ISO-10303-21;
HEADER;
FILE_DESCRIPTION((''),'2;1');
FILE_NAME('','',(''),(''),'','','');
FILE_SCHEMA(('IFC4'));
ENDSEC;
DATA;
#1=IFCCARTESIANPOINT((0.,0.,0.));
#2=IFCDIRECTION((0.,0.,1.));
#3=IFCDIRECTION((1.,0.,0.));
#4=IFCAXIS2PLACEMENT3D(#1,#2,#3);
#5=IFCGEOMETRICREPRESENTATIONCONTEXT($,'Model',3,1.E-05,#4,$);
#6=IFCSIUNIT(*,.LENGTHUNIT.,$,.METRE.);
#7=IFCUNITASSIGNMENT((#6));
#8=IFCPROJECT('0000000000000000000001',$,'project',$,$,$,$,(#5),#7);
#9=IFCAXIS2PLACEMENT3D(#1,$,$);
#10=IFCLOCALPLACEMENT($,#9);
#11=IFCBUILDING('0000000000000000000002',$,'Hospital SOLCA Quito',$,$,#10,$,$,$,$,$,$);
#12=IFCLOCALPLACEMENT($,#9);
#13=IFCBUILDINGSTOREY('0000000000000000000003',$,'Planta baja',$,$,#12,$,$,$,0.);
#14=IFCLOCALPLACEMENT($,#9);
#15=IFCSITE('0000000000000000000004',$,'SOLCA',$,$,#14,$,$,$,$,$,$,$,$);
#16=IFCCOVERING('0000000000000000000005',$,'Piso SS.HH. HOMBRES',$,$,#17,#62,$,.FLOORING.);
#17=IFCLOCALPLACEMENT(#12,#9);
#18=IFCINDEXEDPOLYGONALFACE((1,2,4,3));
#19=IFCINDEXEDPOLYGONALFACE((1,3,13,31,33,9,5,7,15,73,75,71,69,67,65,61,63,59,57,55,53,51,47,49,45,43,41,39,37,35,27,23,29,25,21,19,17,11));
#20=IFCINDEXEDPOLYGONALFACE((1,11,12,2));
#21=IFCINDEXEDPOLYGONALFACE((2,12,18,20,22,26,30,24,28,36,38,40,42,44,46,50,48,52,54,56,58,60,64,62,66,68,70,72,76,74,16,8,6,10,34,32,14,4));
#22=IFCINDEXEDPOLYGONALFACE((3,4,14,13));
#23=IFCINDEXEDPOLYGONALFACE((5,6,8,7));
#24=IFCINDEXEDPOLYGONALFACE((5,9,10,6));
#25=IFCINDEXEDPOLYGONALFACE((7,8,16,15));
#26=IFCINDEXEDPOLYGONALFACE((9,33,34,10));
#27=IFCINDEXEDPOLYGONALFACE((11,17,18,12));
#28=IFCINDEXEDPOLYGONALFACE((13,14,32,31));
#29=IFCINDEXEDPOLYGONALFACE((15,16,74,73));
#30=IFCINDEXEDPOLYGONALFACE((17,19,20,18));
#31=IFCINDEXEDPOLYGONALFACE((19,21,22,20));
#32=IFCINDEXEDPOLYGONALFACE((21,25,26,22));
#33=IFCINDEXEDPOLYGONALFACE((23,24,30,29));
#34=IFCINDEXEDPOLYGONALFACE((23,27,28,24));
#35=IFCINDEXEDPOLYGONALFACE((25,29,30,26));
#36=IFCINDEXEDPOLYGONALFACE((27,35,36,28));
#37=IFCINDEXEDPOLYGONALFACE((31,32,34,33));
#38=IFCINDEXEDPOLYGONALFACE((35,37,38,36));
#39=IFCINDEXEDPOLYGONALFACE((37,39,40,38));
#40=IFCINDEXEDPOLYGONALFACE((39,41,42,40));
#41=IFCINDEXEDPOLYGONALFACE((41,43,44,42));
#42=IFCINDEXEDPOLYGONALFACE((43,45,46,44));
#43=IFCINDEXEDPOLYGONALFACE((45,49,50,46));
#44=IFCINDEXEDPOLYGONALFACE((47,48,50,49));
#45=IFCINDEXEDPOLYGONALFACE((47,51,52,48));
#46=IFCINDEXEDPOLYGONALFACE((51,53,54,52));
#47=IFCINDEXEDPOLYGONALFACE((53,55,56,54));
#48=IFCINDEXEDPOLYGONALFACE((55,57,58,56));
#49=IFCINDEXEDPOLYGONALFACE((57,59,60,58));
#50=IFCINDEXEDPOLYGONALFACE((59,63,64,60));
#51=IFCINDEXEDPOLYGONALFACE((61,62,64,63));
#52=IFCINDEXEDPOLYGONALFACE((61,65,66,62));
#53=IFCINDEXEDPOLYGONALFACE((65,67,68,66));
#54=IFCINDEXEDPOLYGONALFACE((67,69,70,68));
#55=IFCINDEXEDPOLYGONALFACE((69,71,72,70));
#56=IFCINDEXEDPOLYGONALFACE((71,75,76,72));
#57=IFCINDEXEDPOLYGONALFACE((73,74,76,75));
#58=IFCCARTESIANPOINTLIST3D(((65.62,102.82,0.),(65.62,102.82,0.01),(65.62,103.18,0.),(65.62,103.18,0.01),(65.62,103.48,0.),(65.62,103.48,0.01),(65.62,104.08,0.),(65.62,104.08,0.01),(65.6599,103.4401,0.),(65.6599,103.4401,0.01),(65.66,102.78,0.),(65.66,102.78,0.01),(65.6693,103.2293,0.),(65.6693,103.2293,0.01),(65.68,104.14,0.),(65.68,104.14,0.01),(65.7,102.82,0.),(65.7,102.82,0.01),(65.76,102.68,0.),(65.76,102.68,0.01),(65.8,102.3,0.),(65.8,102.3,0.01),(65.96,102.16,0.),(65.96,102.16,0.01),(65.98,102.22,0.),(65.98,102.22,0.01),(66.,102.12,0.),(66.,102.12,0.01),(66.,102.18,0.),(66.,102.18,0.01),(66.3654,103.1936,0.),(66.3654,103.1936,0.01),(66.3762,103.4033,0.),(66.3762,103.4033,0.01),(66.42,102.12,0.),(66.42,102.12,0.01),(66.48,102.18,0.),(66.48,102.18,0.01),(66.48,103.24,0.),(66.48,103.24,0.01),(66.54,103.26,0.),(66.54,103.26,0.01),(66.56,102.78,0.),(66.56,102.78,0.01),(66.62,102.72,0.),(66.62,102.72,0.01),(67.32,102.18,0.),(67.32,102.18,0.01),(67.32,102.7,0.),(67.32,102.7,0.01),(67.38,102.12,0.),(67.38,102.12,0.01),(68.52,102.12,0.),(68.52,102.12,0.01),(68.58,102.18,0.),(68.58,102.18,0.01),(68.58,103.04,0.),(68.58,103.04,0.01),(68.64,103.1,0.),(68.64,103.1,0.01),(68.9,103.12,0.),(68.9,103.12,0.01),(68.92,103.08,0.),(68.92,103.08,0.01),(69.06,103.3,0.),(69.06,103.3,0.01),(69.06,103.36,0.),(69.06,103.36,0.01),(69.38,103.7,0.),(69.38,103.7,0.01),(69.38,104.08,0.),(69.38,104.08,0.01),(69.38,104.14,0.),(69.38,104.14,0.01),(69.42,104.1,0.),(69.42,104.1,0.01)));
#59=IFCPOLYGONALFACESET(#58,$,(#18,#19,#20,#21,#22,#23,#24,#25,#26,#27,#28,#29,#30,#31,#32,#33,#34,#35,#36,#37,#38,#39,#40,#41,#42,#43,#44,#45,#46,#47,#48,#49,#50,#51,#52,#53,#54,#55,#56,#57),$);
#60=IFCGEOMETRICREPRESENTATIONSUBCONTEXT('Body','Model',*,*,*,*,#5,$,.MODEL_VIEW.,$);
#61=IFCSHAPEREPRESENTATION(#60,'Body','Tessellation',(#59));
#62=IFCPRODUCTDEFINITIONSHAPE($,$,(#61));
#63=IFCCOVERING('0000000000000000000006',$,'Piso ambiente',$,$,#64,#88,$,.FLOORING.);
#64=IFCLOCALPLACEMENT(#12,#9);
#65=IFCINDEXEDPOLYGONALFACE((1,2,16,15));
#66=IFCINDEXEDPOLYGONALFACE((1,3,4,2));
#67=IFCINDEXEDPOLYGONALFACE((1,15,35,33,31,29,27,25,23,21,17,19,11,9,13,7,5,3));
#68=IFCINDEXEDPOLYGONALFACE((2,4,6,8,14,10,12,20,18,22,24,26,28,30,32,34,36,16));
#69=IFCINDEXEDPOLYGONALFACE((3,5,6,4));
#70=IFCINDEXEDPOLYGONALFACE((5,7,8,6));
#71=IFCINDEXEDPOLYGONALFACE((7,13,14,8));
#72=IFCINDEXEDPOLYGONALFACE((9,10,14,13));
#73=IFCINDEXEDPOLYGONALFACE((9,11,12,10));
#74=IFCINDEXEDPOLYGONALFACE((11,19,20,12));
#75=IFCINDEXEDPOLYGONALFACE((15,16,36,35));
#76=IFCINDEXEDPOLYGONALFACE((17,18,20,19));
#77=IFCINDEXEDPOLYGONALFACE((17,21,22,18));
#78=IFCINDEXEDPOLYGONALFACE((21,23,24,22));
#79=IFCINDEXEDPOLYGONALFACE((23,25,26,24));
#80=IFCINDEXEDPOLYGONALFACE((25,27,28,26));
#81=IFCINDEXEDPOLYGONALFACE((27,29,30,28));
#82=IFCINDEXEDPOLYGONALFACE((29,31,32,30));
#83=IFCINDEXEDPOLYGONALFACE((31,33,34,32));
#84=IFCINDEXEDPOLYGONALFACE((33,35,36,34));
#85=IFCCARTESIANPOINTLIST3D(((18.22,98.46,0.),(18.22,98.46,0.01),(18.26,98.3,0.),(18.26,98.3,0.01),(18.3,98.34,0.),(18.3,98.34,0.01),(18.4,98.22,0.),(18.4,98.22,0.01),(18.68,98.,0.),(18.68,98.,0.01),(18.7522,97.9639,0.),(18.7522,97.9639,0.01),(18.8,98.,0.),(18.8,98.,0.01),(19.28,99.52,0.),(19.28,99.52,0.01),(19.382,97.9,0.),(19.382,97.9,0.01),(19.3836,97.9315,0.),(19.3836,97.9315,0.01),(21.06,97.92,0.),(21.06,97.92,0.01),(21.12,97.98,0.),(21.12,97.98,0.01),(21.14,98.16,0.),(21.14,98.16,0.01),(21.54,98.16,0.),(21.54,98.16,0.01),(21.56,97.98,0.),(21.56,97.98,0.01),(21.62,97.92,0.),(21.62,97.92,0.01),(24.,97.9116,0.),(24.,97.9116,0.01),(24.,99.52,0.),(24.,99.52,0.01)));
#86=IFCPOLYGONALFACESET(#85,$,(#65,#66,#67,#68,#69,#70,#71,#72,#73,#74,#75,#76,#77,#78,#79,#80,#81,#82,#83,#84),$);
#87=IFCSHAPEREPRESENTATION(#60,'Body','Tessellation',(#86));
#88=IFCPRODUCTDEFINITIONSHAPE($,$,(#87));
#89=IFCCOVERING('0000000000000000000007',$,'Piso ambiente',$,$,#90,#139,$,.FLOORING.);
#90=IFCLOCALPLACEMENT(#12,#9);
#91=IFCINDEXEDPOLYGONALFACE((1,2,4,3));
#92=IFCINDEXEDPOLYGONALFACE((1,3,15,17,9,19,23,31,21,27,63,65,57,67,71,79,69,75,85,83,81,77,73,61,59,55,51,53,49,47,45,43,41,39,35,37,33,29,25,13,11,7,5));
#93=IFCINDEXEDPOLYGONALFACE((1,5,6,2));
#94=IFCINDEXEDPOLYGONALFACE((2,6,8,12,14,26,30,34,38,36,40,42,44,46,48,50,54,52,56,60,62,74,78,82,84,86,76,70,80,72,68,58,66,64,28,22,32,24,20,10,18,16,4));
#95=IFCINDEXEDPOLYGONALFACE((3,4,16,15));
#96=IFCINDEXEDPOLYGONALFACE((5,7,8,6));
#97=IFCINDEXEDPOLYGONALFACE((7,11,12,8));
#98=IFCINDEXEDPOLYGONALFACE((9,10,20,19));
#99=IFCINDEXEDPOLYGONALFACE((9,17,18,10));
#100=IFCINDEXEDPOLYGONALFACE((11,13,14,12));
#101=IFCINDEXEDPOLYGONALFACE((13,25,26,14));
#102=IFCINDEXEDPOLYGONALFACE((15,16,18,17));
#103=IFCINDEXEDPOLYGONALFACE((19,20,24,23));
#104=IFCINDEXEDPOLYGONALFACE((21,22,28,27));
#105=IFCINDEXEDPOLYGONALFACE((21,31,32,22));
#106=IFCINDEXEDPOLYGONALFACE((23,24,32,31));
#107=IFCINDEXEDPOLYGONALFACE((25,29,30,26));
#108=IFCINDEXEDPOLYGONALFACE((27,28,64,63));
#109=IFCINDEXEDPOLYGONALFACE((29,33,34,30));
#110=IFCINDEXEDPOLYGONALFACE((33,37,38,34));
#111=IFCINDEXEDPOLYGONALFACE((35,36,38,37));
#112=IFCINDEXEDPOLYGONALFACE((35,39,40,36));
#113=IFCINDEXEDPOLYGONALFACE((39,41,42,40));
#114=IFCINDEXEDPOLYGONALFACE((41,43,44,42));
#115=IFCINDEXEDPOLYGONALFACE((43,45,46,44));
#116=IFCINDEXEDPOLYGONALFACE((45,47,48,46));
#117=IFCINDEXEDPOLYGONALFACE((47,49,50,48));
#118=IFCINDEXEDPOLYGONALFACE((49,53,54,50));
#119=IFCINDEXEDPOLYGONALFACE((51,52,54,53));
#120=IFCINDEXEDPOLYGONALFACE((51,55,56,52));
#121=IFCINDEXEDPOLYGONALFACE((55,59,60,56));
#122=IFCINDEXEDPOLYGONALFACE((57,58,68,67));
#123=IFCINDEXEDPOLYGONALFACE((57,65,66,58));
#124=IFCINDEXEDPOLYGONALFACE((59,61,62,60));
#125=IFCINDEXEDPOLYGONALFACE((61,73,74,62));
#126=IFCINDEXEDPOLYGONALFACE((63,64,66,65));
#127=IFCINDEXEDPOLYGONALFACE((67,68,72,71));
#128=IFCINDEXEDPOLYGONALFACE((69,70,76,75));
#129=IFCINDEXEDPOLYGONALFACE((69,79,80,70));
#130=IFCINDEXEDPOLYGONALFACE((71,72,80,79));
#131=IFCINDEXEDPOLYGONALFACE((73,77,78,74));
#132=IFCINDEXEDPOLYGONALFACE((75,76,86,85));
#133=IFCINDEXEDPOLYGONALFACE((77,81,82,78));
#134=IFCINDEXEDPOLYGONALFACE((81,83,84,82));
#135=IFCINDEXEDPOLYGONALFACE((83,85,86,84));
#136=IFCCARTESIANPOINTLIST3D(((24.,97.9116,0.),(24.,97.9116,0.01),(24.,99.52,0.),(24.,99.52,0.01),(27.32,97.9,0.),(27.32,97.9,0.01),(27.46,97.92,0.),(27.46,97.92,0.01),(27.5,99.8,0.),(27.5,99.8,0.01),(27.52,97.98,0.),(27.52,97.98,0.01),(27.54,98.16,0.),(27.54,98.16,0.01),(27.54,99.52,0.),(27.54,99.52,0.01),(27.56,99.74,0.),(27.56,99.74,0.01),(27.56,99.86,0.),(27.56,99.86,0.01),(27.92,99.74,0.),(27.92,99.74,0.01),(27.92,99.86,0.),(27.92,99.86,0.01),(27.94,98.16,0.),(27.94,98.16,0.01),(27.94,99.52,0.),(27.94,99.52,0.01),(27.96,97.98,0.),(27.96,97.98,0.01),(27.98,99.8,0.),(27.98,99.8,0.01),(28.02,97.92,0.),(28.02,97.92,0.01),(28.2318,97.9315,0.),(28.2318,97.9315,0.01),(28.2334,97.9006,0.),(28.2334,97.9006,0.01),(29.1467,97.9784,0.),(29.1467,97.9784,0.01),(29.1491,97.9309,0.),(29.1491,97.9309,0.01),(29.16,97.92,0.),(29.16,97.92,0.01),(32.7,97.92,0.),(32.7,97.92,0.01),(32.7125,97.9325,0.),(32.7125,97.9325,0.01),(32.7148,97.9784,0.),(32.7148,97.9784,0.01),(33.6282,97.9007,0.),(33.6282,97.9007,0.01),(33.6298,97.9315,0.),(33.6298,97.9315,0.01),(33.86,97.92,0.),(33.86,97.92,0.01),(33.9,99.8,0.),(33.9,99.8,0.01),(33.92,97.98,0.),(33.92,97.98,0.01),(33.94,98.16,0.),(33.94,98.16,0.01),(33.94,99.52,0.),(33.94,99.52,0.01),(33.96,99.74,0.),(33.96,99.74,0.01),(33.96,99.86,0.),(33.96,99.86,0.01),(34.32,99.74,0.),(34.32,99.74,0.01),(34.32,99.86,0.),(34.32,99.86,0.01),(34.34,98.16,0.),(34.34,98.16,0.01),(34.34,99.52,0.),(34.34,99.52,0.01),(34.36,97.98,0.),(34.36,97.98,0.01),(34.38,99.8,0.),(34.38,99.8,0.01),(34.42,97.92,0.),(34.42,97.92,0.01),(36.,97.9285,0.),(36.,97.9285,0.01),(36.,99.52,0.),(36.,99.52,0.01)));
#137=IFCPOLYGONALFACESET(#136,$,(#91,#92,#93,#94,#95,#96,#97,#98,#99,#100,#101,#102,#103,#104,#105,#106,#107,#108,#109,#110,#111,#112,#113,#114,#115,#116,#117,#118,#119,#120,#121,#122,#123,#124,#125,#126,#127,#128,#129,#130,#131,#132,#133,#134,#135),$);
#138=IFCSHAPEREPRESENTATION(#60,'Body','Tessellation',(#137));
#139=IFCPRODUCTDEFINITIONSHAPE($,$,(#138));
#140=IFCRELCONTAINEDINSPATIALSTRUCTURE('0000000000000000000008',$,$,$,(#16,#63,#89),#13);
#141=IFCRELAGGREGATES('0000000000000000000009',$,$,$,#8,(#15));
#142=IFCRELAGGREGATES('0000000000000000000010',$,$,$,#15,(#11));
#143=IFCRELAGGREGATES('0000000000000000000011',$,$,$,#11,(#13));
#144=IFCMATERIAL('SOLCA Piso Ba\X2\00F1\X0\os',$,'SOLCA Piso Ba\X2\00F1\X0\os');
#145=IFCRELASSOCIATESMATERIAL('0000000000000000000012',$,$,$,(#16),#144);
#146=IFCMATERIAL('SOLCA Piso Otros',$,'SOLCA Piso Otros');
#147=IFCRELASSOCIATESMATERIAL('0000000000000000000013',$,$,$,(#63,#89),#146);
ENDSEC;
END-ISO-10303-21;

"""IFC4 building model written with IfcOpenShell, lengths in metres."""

from ifc_helpers import new_model, si_unit, origin, origin_with_axes, place, context, subcontext, project, spatial, polyline, outline, extrude, material, element, save


model = new_model("IFC4")

# Units and contexts
model_context = context("Model", 3, precision=1e-05, world=origin_with_axes())
body_context = subcontext(model_context, "Body", "Model", "MODEL_VIEW")
ifc_project = project(units=[si_unit("LENGTHUNIT", "METRE")], contexts=[model_context])

# Site, building, storey
site_placement = place(None, origin())
site = spatial("IfcSite", under=ifc_project, at=site_placement, Name="SOLCA")
building_placement = place(None, origin())
building = spatial("IfcBuilding", under=site, at=building_placement, Name="Hospital SOLCA Quito")
storey_placement = place(None, origin())
storey = spatial("IfcBuildingStorey", under=building, at=storey_placement, Name="Planta baja", Elevation=0.0)

# Coverings
ifc_material_1 = material(Name="SOLCA Piso Baños", Category="SOLCA Piso Baños")
covering_1_placement = place(storey_placement, origin_with_axes())
element("IfcCovering", 1, at=covering_1_placement, inside=storey, material=ifc_material_1, Name="Piso SS.HH. HOMBRES", PredefinedType="FLOORING", context=body_context, shape_type="SweptSolid", body=[
    extrude(outline(polyline([(65.62, 103.18), (65.6693, 103.2293), (66.3654, 103.1936), (66.3762, 103.4033), (65.6599, 103.4401), (65.62, 103.48), (65.62, 104.08), (65.68, 104.14), (69.38, 104.14), (69.42, 104.1), (69.38, 104.08), (69.38, 103.7), (69.06, 103.36), (69.06, 103.3), (68.9, 103.12), (68.92, 103.08), (68.64, 103.1), (68.58, 103.04), (68.58, 102.18), (68.52, 102.12), (67.38, 102.12), (67.32, 102.18), (67.32, 102.7), (66.62, 102.72), (66.56, 102.78), (66.54, 103.26), (66.48, 103.24), (66.48, 102.18), (66.42, 102.12), (66.0, 102.12), (65.96, 102.16), (66.0, 102.18), (65.98, 102.22), (65.8, 102.3), (65.76, 102.68), (65.7, 102.82), (65.66, 102.78), (65.62, 102.82), (65.62, 103.18)])), origin_with_axes(), (0.0, 0.0, 1.0), 0.01),
])
ifc_material_2 = material(Name="SOLCA Piso Otros", Category="SOLCA Piso Otros")
covering_2_placement = place(storey_placement, origin_with_axes())
element("IfcCovering", 2, at=covering_2_placement, inside=storey, material=ifc_material_2, Name="Piso ambiente", PredefinedType="FLOORING", context=body_context, shape_type="SweptSolid", body=[
    extrude(outline(polyline([(24.0, 99.52), (24.0, 97.9116), (21.62, 97.92), (21.56, 97.98), (21.54, 98.16), (21.14, 98.16), (21.12, 97.98), (21.06, 97.92), (19.382, 97.9), (19.3836, 97.9315), (18.7522, 97.9639), (18.68, 98.0), (18.8, 98.0), (18.4, 98.22), (18.3, 98.34), (18.26, 98.3), (18.22, 98.46), (19.28, 99.52), (24.0, 99.52)])), origin_with_axes(), (0.0, 0.0, 1.0), 0.01),
])
covering_3_placement = place(storey_placement, origin_with_axes())
element("IfcCovering", 3, at=covering_3_placement, inside=storey, material=ifc_material_2, Name="Piso ambiente", PredefinedType="FLOORING", context=body_context, shape_type="SweptSolid", body=[
    extrude(outline(polyline([(27.54, 99.52), (27.56, 99.74), (27.5, 99.8), (27.56, 99.86), (27.92, 99.86), (27.98, 99.8), (27.92, 99.74), (27.94, 99.52), (33.94, 99.52), (33.96, 99.74), (33.9, 99.8), (33.96, 99.86), (34.32, 99.86), (34.38, 99.8), (34.32, 99.74), (34.34, 99.52), (36.0, 99.52), (36.0, 97.9285), (34.42, 97.92), (34.36, 97.98), (34.34, 98.16), (33.94, 98.16), (33.92, 97.98), (33.86, 97.92), (33.6282, 97.9007), (33.6298, 97.9315), (32.7148, 97.9784), (32.7125, 97.9325), (32.7, 97.92), (29.16, 97.92), (29.1491, 97.9309), (29.1467, 97.9784), (28.2318, 97.9315), (28.2334, 97.9006), (28.02, 97.92), (27.96, 97.98), (27.94, 98.16), (27.54, 98.16), (27.52, 97.98), (27.46, 97.92), (27.32, 97.9), (24.0, 97.9116), (24.0, 99.52), (27.54, 99.52)])), origin_with_axes(), (0.0, 0.0, 1.0), 0.01),
])

save(model, "model.ifc")
